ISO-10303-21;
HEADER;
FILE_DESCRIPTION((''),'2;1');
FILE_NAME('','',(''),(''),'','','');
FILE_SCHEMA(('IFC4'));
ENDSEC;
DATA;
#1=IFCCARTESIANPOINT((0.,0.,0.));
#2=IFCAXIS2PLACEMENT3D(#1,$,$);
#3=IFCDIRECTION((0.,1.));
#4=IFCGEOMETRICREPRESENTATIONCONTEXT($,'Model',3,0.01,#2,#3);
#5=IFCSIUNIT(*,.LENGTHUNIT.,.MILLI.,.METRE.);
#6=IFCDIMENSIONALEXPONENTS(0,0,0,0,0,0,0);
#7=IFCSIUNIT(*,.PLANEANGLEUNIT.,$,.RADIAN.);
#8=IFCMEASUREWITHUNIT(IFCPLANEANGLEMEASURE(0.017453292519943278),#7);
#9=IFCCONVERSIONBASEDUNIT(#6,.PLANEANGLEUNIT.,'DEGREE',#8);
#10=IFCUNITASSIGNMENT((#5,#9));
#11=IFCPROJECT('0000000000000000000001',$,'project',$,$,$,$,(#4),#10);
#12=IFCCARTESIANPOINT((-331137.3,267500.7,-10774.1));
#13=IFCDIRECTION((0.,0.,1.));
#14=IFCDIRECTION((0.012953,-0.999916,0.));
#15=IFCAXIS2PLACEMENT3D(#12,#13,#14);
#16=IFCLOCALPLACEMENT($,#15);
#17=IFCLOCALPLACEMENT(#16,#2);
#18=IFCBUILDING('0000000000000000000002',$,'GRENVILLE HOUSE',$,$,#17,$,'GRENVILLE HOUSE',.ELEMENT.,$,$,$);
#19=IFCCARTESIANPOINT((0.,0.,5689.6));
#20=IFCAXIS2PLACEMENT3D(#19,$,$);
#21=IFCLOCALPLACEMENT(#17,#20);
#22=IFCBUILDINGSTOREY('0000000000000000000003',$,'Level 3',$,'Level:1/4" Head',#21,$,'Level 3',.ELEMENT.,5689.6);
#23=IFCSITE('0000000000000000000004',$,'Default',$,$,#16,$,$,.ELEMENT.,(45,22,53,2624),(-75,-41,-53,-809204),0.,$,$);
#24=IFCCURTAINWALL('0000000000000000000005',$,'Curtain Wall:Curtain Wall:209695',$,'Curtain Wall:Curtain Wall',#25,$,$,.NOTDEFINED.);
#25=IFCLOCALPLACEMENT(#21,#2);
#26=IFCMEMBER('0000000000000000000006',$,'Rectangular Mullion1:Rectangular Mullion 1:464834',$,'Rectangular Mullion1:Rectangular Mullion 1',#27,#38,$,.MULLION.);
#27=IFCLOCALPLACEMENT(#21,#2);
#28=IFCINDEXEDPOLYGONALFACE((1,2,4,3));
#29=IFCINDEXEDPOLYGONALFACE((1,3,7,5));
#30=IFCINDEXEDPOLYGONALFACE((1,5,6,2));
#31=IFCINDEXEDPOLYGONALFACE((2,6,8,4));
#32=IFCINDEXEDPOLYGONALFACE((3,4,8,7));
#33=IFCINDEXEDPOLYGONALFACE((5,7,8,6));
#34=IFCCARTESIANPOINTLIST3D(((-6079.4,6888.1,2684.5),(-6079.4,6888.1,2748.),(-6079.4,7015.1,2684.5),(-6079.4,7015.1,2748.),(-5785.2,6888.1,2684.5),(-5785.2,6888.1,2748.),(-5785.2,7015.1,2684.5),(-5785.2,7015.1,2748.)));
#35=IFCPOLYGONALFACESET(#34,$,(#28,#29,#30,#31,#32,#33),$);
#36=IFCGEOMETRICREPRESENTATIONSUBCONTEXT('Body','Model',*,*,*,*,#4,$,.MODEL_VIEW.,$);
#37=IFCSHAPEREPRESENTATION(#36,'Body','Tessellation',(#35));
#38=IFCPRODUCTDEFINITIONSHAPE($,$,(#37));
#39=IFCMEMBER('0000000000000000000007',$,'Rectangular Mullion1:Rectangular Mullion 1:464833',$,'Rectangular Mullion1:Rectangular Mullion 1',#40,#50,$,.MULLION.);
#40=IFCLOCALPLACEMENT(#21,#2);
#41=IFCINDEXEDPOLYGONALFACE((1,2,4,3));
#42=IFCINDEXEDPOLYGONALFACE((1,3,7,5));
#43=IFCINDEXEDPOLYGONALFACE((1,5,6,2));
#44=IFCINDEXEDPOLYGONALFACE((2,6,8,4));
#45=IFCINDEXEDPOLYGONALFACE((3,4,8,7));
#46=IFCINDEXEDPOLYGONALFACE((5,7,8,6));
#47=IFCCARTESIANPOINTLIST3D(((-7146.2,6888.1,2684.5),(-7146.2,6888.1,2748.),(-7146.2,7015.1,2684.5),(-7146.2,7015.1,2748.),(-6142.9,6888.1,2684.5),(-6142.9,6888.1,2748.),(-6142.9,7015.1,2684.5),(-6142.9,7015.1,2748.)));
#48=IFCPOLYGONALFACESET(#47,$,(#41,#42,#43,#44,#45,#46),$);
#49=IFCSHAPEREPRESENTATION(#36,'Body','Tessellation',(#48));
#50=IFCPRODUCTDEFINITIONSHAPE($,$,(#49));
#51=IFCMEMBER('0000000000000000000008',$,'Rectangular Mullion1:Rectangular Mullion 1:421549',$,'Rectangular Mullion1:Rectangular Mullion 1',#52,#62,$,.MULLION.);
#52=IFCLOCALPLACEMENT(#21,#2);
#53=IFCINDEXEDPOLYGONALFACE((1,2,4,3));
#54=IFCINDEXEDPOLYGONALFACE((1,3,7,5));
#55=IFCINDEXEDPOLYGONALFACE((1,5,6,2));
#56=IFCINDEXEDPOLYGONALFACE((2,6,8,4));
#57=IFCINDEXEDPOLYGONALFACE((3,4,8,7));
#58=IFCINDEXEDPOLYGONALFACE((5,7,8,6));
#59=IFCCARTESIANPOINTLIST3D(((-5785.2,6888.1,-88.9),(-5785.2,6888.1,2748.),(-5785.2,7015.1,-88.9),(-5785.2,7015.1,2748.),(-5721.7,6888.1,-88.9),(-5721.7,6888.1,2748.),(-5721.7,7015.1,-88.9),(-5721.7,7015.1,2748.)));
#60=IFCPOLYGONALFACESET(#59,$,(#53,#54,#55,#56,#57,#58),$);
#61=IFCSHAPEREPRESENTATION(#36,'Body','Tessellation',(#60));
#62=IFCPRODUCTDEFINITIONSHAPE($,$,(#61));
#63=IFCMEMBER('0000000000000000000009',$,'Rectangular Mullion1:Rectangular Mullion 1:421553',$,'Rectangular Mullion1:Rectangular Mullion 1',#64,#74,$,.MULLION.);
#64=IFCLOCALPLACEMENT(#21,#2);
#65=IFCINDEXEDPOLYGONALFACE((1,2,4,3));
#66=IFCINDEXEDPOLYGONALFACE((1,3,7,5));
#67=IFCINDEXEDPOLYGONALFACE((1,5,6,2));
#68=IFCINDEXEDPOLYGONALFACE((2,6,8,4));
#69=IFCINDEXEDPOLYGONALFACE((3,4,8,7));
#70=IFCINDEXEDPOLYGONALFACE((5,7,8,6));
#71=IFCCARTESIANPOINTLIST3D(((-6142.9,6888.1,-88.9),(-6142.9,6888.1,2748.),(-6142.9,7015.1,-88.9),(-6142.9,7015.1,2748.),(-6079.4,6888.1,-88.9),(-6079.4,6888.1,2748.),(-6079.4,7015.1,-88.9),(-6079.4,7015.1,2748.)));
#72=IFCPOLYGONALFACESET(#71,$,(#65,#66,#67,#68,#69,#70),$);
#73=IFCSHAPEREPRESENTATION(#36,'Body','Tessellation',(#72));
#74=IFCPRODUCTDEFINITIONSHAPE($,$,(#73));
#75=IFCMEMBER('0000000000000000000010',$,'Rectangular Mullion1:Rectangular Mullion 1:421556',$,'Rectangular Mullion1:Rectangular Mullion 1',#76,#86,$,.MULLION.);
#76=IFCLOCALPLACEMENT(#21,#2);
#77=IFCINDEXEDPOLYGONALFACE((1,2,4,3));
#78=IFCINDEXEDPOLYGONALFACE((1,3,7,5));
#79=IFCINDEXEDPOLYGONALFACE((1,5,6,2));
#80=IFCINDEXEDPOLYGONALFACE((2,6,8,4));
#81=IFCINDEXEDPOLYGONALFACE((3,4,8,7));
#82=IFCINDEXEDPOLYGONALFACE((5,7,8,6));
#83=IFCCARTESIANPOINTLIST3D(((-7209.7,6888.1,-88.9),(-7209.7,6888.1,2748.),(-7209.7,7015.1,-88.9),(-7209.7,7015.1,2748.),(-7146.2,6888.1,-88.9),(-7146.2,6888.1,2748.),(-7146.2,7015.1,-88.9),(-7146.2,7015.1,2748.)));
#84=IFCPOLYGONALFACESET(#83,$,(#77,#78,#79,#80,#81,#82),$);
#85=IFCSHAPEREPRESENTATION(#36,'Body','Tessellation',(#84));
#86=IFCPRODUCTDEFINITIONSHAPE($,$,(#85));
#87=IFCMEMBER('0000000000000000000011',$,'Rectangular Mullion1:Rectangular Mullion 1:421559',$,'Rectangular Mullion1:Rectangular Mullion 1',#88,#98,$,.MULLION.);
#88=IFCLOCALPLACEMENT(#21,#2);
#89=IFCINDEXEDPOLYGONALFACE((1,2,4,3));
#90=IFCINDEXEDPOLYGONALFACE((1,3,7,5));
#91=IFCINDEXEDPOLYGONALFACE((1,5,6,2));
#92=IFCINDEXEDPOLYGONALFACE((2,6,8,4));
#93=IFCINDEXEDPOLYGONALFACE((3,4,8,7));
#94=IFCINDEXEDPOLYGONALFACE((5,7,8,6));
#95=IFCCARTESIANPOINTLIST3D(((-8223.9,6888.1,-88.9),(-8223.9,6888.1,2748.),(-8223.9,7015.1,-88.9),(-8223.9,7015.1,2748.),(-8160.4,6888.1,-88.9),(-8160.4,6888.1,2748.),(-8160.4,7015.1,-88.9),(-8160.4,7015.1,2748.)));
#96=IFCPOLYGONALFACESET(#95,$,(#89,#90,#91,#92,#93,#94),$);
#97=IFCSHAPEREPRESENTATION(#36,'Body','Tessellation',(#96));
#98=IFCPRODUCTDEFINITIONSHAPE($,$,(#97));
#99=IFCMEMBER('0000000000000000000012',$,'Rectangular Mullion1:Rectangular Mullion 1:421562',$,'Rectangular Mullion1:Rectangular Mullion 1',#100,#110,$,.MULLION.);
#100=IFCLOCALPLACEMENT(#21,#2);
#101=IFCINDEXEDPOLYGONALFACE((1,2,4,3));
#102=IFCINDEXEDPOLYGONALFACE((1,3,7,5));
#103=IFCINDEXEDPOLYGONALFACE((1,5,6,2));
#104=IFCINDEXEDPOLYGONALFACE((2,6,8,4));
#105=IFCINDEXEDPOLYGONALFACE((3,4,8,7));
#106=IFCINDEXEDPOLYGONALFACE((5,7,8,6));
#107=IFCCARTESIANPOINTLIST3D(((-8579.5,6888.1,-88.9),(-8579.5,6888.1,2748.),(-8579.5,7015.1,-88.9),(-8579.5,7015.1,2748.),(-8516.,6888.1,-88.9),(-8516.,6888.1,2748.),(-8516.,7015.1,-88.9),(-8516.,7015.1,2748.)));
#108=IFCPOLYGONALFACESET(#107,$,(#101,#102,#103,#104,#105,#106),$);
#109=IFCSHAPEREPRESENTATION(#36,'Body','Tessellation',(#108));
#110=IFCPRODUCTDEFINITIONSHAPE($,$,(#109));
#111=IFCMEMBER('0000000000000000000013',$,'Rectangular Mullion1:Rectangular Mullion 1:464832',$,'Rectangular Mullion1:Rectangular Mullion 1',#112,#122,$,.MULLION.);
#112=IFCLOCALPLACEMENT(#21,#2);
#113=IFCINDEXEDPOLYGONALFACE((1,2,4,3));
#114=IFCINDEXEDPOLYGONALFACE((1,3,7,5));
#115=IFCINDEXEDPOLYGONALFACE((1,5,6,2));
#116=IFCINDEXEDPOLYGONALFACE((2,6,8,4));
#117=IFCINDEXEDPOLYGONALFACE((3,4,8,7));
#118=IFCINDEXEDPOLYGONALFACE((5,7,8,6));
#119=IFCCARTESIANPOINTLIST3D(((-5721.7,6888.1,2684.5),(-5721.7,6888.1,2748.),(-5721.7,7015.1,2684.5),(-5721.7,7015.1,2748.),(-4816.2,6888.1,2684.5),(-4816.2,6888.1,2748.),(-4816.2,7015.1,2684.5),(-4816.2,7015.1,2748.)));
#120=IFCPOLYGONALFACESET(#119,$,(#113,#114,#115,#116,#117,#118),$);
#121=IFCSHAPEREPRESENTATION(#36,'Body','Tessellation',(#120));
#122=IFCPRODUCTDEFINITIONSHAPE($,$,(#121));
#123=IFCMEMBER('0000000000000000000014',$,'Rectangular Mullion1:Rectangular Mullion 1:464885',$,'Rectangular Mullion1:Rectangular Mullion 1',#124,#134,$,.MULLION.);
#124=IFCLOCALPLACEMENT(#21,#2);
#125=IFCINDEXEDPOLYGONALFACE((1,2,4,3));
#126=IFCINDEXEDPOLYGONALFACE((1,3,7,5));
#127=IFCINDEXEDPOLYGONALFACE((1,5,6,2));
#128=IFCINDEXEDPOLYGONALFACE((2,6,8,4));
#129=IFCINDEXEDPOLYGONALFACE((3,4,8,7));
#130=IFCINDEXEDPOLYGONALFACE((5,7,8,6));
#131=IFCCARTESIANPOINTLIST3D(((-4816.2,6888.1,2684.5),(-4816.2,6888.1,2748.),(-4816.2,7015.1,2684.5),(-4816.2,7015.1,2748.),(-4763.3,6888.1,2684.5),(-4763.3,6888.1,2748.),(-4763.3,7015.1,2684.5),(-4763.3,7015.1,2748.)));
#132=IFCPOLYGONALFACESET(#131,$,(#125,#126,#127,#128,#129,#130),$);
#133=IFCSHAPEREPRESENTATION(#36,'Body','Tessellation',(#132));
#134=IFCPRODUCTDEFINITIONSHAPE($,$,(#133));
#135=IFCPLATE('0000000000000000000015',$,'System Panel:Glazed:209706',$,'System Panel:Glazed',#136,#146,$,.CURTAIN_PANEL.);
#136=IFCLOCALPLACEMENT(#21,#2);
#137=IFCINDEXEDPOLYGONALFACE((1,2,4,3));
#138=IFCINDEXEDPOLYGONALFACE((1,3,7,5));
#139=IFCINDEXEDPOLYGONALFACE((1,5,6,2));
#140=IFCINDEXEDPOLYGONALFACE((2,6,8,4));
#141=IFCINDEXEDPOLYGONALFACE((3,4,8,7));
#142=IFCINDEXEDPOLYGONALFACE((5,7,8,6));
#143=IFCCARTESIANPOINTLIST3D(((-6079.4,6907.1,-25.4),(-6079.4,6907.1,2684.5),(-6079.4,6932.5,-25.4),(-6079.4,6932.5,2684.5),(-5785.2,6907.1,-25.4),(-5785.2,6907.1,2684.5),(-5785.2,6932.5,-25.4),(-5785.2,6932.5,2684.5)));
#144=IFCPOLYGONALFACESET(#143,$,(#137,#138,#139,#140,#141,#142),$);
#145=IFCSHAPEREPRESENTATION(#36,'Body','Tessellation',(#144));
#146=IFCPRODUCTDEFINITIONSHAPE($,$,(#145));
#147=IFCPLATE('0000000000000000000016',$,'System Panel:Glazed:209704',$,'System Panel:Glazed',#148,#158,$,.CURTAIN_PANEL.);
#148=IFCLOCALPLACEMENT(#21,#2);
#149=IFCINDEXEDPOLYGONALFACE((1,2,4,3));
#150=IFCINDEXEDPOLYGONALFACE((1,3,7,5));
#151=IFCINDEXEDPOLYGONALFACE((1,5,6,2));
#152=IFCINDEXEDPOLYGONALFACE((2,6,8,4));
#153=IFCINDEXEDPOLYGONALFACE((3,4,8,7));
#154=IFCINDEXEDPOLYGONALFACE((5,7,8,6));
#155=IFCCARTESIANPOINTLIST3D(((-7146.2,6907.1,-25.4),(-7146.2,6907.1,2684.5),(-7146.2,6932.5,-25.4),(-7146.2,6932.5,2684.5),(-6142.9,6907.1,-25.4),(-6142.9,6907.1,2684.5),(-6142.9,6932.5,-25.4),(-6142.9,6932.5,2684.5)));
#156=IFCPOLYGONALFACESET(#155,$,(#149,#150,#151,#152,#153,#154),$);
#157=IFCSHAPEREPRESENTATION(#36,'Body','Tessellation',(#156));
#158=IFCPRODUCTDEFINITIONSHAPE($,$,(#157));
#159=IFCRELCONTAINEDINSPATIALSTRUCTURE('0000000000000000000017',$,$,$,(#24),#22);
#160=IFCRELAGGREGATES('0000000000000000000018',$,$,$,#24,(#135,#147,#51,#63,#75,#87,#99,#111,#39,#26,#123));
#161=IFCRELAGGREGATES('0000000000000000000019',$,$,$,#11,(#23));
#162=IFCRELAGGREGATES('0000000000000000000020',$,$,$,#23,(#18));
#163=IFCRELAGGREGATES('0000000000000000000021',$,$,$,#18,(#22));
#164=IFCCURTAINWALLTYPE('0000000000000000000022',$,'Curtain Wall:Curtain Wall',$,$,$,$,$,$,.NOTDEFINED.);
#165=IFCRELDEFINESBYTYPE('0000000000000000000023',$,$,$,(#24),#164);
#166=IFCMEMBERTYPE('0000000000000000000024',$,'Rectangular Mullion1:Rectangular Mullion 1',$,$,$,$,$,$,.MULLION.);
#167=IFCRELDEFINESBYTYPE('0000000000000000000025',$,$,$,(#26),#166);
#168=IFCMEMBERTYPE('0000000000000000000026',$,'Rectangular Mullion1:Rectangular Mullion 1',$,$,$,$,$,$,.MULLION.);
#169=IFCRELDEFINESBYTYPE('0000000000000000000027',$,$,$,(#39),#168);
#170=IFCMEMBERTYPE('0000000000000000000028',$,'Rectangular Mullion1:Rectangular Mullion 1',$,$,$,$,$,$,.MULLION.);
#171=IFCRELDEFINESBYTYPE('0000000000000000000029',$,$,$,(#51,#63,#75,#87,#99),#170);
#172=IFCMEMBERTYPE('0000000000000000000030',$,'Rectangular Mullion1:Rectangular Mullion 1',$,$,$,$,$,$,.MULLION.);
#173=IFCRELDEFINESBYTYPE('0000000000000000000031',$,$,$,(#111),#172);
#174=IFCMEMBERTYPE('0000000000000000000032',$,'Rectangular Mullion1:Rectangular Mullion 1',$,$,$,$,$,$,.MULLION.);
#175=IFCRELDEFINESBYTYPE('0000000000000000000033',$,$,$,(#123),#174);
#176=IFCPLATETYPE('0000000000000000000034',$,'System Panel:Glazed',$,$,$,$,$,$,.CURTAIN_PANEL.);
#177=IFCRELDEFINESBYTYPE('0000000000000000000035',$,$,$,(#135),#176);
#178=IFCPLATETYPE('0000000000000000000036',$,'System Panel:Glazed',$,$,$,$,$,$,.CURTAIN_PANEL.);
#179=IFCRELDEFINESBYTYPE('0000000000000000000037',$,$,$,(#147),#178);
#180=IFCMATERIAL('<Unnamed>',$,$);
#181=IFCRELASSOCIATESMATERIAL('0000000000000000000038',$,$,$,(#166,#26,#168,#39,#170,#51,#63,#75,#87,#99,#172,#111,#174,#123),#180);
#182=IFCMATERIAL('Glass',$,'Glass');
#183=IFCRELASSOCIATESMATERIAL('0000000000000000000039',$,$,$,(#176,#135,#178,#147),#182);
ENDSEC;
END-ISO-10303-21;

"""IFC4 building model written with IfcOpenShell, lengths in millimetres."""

from ifc_helpers import new_model, entity, si_unit, converted_unit, direction, frame, origin, place, context, subcontext, project, spatial, indexed_curve, outline, extrude, source, transform, mapped, material, type_object, type_shapes, element, aggregate, save


model = new_model("IFC4")

# Units and contexts
model_context = context("Model", 3, precision=0.01, world=origin(), true_north=direction((0.0, 1.0)))
body_context = subcontext(model_context, "Body", "Model", "MODEL_VIEW")
ifc_project = project(units=[si_unit("LENGTHUNIT", "METRE", prefix="MILLI"), converted_unit("PLANEANGLEUNIT", "DEGREE", entity("IfcPlaneAngleMeasure", 0.017453292519943278), si_unit("PLANEANGLEUNIT", "RADIAN"), dimensions=[0, 0, 0, 0, 0, 0, 0])], contexts=[model_context])

# Site, building, storey
site_placement = place(None, frame((-331137.3, 267500.7, -10774.1), z_axis=(0.0, 0.0, 1.0), x_axis=(0.012953, -0.999916, 0.0)))
site = spatial("IfcSite", under=ifc_project, at=site_placement, Name="Default", CompositionType="ELEMENT", RefLatitude=(45, 22, 53, 2624), RefLongitude=(-75, -41, -53, -809204), RefElevation=0.0)
building_placement = place(site_placement, origin())
building = spatial("IfcBuilding", under=site, at=building_placement, Name="GRENVILLE HOUSE", LongName="GRENVILLE HOUSE", CompositionType="ELEMENT")
storey_placement = place(building_placement, frame((0.0, 0.0, 5689.6)))
storey = spatial("IfcBuildingStorey", under=building, at=storey_placement, Name="Level 3", ObjectType="Level:1/4\" Head", LongName="Level 3", CompositionType="ELEMENT", Elevation=5689.6)

# Curtain wall
curtain_wall_type = type_object("IfcCurtainWallType", Name="Curtain Wall:Curtain Wall", PredefinedType="NOTDEFINED")
curtain_wall_placement = place(storey_placement, frame((0.0, 0.0, -5689.6)))
curtain_wall = element("IfcCurtainWall", 1, at=curtain_wall_placement, inside=storey, type_object=curtain_wall_type, Name="Curtain Wall:Curtain Wall:209695", ObjectType="Curtain Wall:Curtain Wall", PredefinedType="NOTDEFINED")
ifc_material_1 = material(Name="<Unnamed>")

# Members
member_type_1 = type_object("IfcMemberType", Name="Rectangular Mullion1:Rectangular Mullion 1", PredefinedType="MULLION", material=ifc_material_1)
shared_shape_1 = source(origin(), body_context, "Body", "SweptSolid", [
    extrude(outline(indexed_curve([(-31.8, -63.5), (31.8, -63.5), (31.8, 63.5), (-31.8, 63.5), (-31.8, -63.5)], self_intersect=False)), frame((-31.8, 0.0, -294.2), z_axis=(0.0, 0.0, 1.0), x_axis=(-1.0, 0.0, 0.0)), (0.0, 0.0, 1.0), 294.2),
])
type_shapes(member_type_1, [shared_shape_1])
member_1_placement = place(curtain_wall_placement, frame((-6079.4, 6951.6, 8437.6), z_axis=(-1.0, 0.0, 0.0), x_axis=(0.0, 0.0, 1.0)))
member_1 = element("IfcMember", 2, at=member_1_placement, type_object=member_type_1, material=ifc_material_1, Name="Rectangular Mullion1:Rectangular Mullion 1:464834", ObjectType="Rectangular Mullion1:Rectangular Mullion 1", PredefinedType="MULLION", context=body_context, shape_type="MappedRepresentation", body=[
    mapped(shared_shape_1, transform((0.0, 0.0, 0.0), scale=1.0)),
])
member_type_2 = type_object("IfcMemberType", Name="Rectangular Mullion1:Rectangular Mullion 1", PredefinedType="MULLION", material=ifc_material_1)
shared_shape_2 = source(origin(), body_context, "Body", "SweptSolid", [
    extrude(outline(indexed_curve([(-31.8, -63.5), (31.8, -63.5), (31.8, 63.5), (-31.8, 63.5), (-31.8, -63.5)], self_intersect=False)), frame((-31.8, 0.0, -1003.3), z_axis=(0.0, 0.0, 1.0), x_axis=(-1.0, 0.0, 0.0)), (0.0, 0.0, 1.0), 1003.3),
])
type_shapes(member_type_2, [shared_shape_2])
member_2_placement = place(curtain_wall_placement, frame((-7146.2, 6951.6, 8437.6), z_axis=(-1.0, 0.0, 0.0), x_axis=(0.0, 0.0, 1.0)))
member_2 = element("IfcMember", 3, at=member_2_placement, type_object=member_type_2, material=ifc_material_1, Name="Rectangular Mullion1:Rectangular Mullion 1:464833", ObjectType="Rectangular Mullion1:Rectangular Mullion 1", PredefinedType="MULLION", context=body_context, shape_type="MappedRepresentation", body=[
    mapped(shared_shape_2, transform((0.0, 0.0, 0.0), scale=1.0)),
])
member_type_3 = type_object("IfcMemberType", Name="Rectangular Mullion1:Rectangular Mullion 1", PredefinedType="MULLION", material=ifc_material_1)
shared_shape_3 = source(origin(), body_context, "Body", "SweptSolid", [
    extrude(outline(indexed_curve([(-31.8, -63.5), (31.8, -63.5), (31.8, 63.5), (-31.8, 63.5), (-31.8, -63.5)], self_intersect=False)), frame((0.0, 0.0, -2836.9), z_axis=(0.0, 0.0, 1.0), x_axis=(-1.0, 0.0, 0.0)), (0.0, 0.0, 1.0), 2836.9),
])
type_shapes(member_type_3, [shared_shape_3])
member_3_placement = place(curtain_wall_placement, frame((-5753.4, 6951.6, 5600.7), z_axis=(0.0, 0.0, -1.0), x_axis=(-1.0, 0.0, 0.0)))
member_3 = element("IfcMember", 4, at=member_3_placement, type_object=member_type_3, material=ifc_material_1, Name="Rectangular Mullion1:Rectangular Mullion 1:421549", ObjectType="Rectangular Mullion1:Rectangular Mullion 1", PredefinedType="MULLION", context=body_context, shape_type="MappedRepresentation", body=[
    mapped(shared_shape_3, transform((0.0, 0.0, 0.0), scale=1.0)),
])
member_4_placement = place(curtain_wall_placement, frame((-6111.1, 6951.6, 5600.7), z_axis=(0.0, 0.0, -1.0), x_axis=(-1.0, 0.0, 0.0)))
member_4 = element("IfcMember", 5, at=member_4_placement, type_object=member_type_3, material=ifc_material_1, Name="Rectangular Mullion1:Rectangular Mullion 1:421553", ObjectType="Rectangular Mullion1:Rectangular Mullion 1", PredefinedType="MULLION", context=body_context, shape_type="MappedRepresentation", body=[
    mapped(shared_shape_3, transform((0.0, 0.0, 0.0), scale=1.0)),
])
member_5_placement = place(curtain_wall_placement, frame((-7177.9, 6951.6, 5600.7), z_axis=(0.0, 0.0, -1.0), x_axis=(-1.0, 0.0, 0.0)))
member_5 = element("IfcMember", 6, at=member_5_placement, type_object=member_type_3, material=ifc_material_1, Name="Rectangular Mullion1:Rectangular Mullion 1:421556", ObjectType="Rectangular Mullion1:Rectangular Mullion 1", PredefinedType="MULLION", context=body_context, shape_type="MappedRepresentation", body=[
    mapped(shared_shape_3, transform((0.0, 0.0, 0.0), scale=1.0)),
])
member_6_placement = place(curtain_wall_placement, frame((-8192.1, 6951.6, 5600.7), z_axis=(0.0, 0.0, -1.0), x_axis=(-1.0, 0.0, 0.0)))
member_6 = element("IfcMember", 7, at=member_6_placement, type_object=member_type_3, material=ifc_material_1, Name="Rectangular Mullion1:Rectangular Mullion 1:421559", ObjectType="Rectangular Mullion1:Rectangular Mullion 1", PredefinedType="MULLION", context=body_context, shape_type="MappedRepresentation", body=[
    mapped(shared_shape_3, transform((0.0, 0.0, 0.0), scale=1.0)),
])
member_7_placement = place(curtain_wall_placement, frame((-8547.7, 6951.6, 5600.7), z_axis=(0.0, 0.0, -1.0), x_axis=(-1.0, 0.0, 0.0)))
member_7 = element("IfcMember", 8, at=member_7_placement, type_object=member_type_3, material=ifc_material_1, Name="Rectangular Mullion1:Rectangular Mullion 1:421562", ObjectType="Rectangular Mullion1:Rectangular Mullion 1", PredefinedType="MULLION", context=body_context, shape_type="MappedRepresentation", body=[
    mapped(shared_shape_3, transform((0.0, 0.0, 0.0), scale=1.0)),
])
member_type_4 = type_object("IfcMemberType", Name="Rectangular Mullion1:Rectangular Mullion 1", PredefinedType="MULLION", material=ifc_material_1)
shared_shape_4 = source(origin(), body_context, "Body", "SweptSolid", [
    extrude(outline(indexed_curve([(-31.8, -63.5), (31.8, -63.5), (31.8, 63.5), (-31.8, 63.5), (-31.8, -63.5)], self_intersect=False)), frame((-31.8, 0.0, -905.5), z_axis=(0.0, 0.0, 1.0), x_axis=(-1.0, 0.0, 0.0)), (0.0, 0.0, 1.0), 905.5),
])
type_shapes(member_type_4, [shared_shape_4])
member_8_placement = place(curtain_wall_placement, frame((-5721.7, 6951.6, 8437.6), z_axis=(-1.0, 0.0, 0.0), x_axis=(0.0, 0.0, 1.0)))
member_8 = element("IfcMember", 9, at=member_8_placement, type_object=member_type_4, material=ifc_material_1, Name="Rectangular Mullion1:Rectangular Mullion 1:464832", ObjectType="Rectangular Mullion1:Rectangular Mullion 1", PredefinedType="MULLION", context=body_context, shape_type="MappedRepresentation", body=[
    mapped(shared_shape_4, transform((0.0, 0.0, 0.0), scale=1.0)),
])
member_type_5 = type_object("IfcMemberType", Name="Rectangular Mullion1:Rectangular Mullion 1", PredefinedType="MULLION", material=ifc_material_1)
shared_shape_5 = source(origin(), body_context, "Body", "SweptSolid", [
    extrude(outline(indexed_curve([(-31.8, -63.5), (31.8, -63.5), (31.8, 63.5), (-31.8, 63.5), (-31.8, -63.5)], self_intersect=False)), frame((-31.8, 0.0, -52.9), z_axis=(0.0, 0.0, 1.0), x_axis=(-1.0, 0.0, 0.0)), (0.0, 0.0, 1.0), 52.9),
])
type_shapes(member_type_5, [shared_shape_5])
member_9_placement = place(curtain_wall_placement, frame((-4816.2, 6951.6, 8437.6), z_axis=(-1.0, 0.0, 0.0), x_axis=(0.0, 0.0, 1.0)))
member_9 = element("IfcMember", 10, at=member_9_placement, type_object=member_type_5, material=ifc_material_1, Name="Rectangular Mullion1:Rectangular Mullion 1:464885", ObjectType="Rectangular Mullion1:Rectangular Mullion 1", PredefinedType="MULLION", context=body_context, shape_type="MappedRepresentation", body=[
    mapped(shared_shape_5, transform((0.0, 0.0, 0.0), scale=1.0)),
])

# Plates
ifc_material_2 = material(Name="Glass", Category="Glass")
plate_type_1 = type_object("IfcPlateType", Name="System Panel:Glazed", PredefinedType="CURTAIN_PANEL", material=ifc_material_2)
shared_shape_6 = source(origin(), body_context, "Body", "SweptSolid", [
    extrude(outline(indexed_curve([(-12.7, -147.1), (12.7, -147.1), (12.7, 147.1), (-12.7, 147.1), (-12.7, -147.1)], self_intersect=False)), frame((147.1, 12.7, 0.0), z_axis=(0.0, 0.0, 1.0), x_axis=(0.0, 1.0, 0.0)), (0.0, 0.0, 1.0), 2709.9),
])
type_shapes(plate_type_1, [shared_shape_6])
plate_1_placement = place(curtain_wall_placement, frame((-5785.2, 6932.5, 5664.2), z_axis=(0.0, 0.0, 1.0), x_axis=(-1.0, 0.0, 0.0)))
plate_1 = element("IfcPlate", 11, at=plate_1_placement, type_object=plate_type_1, material=ifc_material_2, Name="System Panel:Glazed:209706", ObjectType="System Panel:Glazed", PredefinedType="CURTAIN_PANEL", context=body_context, shape_type="MappedRepresentation", body=[
    mapped(shared_shape_6, transform((0.0, 0.0, 0.0), scale=1.0)),
])
plate_type_2 = type_object("IfcPlateType", Name="System Panel:Glazed", PredefinedType="CURTAIN_PANEL", material=ifc_material_2)
shared_shape_7 = source(origin(), body_context, "Body", "SweptSolid", [
    extrude(outline(indexed_curve([(-12.7, -501.6), (12.7, -501.6), (12.7, 501.6), (-12.7, 501.6), (-12.7, -501.6)], self_intersect=False)), frame((501.6, 12.7, 0.0), z_axis=(0.0, 0.0, 1.0), x_axis=(0.0, 1.0, 0.0)), (0.0, 0.0, 1.0), 2709.9),
])
type_shapes(plate_type_2, [shared_shape_7])
plate_2_placement = place(curtain_wall_placement, frame((-6142.9, 6932.5, 5664.2), z_axis=(0.0, 0.0, 1.0), x_axis=(-1.0, 0.0, 0.0)))
plate_2 = element("IfcPlate", 12, at=plate_2_placement, type_object=plate_type_2, material=ifc_material_2, Name="System Panel:Glazed:209704", ObjectType="System Panel:Glazed", PredefinedType="CURTAIN_PANEL", context=body_context, shape_type="MappedRepresentation", body=[
    mapped(shared_shape_7, transform((0.0, 0.0, 0.0), scale=1.0)),
])
aggregate(curtain_wall, [plate_1, plate_2, member_3, member_4, member_5, member_6, member_7, member_8, member_2, member_1, member_9])

save(model, "model.ifc")
